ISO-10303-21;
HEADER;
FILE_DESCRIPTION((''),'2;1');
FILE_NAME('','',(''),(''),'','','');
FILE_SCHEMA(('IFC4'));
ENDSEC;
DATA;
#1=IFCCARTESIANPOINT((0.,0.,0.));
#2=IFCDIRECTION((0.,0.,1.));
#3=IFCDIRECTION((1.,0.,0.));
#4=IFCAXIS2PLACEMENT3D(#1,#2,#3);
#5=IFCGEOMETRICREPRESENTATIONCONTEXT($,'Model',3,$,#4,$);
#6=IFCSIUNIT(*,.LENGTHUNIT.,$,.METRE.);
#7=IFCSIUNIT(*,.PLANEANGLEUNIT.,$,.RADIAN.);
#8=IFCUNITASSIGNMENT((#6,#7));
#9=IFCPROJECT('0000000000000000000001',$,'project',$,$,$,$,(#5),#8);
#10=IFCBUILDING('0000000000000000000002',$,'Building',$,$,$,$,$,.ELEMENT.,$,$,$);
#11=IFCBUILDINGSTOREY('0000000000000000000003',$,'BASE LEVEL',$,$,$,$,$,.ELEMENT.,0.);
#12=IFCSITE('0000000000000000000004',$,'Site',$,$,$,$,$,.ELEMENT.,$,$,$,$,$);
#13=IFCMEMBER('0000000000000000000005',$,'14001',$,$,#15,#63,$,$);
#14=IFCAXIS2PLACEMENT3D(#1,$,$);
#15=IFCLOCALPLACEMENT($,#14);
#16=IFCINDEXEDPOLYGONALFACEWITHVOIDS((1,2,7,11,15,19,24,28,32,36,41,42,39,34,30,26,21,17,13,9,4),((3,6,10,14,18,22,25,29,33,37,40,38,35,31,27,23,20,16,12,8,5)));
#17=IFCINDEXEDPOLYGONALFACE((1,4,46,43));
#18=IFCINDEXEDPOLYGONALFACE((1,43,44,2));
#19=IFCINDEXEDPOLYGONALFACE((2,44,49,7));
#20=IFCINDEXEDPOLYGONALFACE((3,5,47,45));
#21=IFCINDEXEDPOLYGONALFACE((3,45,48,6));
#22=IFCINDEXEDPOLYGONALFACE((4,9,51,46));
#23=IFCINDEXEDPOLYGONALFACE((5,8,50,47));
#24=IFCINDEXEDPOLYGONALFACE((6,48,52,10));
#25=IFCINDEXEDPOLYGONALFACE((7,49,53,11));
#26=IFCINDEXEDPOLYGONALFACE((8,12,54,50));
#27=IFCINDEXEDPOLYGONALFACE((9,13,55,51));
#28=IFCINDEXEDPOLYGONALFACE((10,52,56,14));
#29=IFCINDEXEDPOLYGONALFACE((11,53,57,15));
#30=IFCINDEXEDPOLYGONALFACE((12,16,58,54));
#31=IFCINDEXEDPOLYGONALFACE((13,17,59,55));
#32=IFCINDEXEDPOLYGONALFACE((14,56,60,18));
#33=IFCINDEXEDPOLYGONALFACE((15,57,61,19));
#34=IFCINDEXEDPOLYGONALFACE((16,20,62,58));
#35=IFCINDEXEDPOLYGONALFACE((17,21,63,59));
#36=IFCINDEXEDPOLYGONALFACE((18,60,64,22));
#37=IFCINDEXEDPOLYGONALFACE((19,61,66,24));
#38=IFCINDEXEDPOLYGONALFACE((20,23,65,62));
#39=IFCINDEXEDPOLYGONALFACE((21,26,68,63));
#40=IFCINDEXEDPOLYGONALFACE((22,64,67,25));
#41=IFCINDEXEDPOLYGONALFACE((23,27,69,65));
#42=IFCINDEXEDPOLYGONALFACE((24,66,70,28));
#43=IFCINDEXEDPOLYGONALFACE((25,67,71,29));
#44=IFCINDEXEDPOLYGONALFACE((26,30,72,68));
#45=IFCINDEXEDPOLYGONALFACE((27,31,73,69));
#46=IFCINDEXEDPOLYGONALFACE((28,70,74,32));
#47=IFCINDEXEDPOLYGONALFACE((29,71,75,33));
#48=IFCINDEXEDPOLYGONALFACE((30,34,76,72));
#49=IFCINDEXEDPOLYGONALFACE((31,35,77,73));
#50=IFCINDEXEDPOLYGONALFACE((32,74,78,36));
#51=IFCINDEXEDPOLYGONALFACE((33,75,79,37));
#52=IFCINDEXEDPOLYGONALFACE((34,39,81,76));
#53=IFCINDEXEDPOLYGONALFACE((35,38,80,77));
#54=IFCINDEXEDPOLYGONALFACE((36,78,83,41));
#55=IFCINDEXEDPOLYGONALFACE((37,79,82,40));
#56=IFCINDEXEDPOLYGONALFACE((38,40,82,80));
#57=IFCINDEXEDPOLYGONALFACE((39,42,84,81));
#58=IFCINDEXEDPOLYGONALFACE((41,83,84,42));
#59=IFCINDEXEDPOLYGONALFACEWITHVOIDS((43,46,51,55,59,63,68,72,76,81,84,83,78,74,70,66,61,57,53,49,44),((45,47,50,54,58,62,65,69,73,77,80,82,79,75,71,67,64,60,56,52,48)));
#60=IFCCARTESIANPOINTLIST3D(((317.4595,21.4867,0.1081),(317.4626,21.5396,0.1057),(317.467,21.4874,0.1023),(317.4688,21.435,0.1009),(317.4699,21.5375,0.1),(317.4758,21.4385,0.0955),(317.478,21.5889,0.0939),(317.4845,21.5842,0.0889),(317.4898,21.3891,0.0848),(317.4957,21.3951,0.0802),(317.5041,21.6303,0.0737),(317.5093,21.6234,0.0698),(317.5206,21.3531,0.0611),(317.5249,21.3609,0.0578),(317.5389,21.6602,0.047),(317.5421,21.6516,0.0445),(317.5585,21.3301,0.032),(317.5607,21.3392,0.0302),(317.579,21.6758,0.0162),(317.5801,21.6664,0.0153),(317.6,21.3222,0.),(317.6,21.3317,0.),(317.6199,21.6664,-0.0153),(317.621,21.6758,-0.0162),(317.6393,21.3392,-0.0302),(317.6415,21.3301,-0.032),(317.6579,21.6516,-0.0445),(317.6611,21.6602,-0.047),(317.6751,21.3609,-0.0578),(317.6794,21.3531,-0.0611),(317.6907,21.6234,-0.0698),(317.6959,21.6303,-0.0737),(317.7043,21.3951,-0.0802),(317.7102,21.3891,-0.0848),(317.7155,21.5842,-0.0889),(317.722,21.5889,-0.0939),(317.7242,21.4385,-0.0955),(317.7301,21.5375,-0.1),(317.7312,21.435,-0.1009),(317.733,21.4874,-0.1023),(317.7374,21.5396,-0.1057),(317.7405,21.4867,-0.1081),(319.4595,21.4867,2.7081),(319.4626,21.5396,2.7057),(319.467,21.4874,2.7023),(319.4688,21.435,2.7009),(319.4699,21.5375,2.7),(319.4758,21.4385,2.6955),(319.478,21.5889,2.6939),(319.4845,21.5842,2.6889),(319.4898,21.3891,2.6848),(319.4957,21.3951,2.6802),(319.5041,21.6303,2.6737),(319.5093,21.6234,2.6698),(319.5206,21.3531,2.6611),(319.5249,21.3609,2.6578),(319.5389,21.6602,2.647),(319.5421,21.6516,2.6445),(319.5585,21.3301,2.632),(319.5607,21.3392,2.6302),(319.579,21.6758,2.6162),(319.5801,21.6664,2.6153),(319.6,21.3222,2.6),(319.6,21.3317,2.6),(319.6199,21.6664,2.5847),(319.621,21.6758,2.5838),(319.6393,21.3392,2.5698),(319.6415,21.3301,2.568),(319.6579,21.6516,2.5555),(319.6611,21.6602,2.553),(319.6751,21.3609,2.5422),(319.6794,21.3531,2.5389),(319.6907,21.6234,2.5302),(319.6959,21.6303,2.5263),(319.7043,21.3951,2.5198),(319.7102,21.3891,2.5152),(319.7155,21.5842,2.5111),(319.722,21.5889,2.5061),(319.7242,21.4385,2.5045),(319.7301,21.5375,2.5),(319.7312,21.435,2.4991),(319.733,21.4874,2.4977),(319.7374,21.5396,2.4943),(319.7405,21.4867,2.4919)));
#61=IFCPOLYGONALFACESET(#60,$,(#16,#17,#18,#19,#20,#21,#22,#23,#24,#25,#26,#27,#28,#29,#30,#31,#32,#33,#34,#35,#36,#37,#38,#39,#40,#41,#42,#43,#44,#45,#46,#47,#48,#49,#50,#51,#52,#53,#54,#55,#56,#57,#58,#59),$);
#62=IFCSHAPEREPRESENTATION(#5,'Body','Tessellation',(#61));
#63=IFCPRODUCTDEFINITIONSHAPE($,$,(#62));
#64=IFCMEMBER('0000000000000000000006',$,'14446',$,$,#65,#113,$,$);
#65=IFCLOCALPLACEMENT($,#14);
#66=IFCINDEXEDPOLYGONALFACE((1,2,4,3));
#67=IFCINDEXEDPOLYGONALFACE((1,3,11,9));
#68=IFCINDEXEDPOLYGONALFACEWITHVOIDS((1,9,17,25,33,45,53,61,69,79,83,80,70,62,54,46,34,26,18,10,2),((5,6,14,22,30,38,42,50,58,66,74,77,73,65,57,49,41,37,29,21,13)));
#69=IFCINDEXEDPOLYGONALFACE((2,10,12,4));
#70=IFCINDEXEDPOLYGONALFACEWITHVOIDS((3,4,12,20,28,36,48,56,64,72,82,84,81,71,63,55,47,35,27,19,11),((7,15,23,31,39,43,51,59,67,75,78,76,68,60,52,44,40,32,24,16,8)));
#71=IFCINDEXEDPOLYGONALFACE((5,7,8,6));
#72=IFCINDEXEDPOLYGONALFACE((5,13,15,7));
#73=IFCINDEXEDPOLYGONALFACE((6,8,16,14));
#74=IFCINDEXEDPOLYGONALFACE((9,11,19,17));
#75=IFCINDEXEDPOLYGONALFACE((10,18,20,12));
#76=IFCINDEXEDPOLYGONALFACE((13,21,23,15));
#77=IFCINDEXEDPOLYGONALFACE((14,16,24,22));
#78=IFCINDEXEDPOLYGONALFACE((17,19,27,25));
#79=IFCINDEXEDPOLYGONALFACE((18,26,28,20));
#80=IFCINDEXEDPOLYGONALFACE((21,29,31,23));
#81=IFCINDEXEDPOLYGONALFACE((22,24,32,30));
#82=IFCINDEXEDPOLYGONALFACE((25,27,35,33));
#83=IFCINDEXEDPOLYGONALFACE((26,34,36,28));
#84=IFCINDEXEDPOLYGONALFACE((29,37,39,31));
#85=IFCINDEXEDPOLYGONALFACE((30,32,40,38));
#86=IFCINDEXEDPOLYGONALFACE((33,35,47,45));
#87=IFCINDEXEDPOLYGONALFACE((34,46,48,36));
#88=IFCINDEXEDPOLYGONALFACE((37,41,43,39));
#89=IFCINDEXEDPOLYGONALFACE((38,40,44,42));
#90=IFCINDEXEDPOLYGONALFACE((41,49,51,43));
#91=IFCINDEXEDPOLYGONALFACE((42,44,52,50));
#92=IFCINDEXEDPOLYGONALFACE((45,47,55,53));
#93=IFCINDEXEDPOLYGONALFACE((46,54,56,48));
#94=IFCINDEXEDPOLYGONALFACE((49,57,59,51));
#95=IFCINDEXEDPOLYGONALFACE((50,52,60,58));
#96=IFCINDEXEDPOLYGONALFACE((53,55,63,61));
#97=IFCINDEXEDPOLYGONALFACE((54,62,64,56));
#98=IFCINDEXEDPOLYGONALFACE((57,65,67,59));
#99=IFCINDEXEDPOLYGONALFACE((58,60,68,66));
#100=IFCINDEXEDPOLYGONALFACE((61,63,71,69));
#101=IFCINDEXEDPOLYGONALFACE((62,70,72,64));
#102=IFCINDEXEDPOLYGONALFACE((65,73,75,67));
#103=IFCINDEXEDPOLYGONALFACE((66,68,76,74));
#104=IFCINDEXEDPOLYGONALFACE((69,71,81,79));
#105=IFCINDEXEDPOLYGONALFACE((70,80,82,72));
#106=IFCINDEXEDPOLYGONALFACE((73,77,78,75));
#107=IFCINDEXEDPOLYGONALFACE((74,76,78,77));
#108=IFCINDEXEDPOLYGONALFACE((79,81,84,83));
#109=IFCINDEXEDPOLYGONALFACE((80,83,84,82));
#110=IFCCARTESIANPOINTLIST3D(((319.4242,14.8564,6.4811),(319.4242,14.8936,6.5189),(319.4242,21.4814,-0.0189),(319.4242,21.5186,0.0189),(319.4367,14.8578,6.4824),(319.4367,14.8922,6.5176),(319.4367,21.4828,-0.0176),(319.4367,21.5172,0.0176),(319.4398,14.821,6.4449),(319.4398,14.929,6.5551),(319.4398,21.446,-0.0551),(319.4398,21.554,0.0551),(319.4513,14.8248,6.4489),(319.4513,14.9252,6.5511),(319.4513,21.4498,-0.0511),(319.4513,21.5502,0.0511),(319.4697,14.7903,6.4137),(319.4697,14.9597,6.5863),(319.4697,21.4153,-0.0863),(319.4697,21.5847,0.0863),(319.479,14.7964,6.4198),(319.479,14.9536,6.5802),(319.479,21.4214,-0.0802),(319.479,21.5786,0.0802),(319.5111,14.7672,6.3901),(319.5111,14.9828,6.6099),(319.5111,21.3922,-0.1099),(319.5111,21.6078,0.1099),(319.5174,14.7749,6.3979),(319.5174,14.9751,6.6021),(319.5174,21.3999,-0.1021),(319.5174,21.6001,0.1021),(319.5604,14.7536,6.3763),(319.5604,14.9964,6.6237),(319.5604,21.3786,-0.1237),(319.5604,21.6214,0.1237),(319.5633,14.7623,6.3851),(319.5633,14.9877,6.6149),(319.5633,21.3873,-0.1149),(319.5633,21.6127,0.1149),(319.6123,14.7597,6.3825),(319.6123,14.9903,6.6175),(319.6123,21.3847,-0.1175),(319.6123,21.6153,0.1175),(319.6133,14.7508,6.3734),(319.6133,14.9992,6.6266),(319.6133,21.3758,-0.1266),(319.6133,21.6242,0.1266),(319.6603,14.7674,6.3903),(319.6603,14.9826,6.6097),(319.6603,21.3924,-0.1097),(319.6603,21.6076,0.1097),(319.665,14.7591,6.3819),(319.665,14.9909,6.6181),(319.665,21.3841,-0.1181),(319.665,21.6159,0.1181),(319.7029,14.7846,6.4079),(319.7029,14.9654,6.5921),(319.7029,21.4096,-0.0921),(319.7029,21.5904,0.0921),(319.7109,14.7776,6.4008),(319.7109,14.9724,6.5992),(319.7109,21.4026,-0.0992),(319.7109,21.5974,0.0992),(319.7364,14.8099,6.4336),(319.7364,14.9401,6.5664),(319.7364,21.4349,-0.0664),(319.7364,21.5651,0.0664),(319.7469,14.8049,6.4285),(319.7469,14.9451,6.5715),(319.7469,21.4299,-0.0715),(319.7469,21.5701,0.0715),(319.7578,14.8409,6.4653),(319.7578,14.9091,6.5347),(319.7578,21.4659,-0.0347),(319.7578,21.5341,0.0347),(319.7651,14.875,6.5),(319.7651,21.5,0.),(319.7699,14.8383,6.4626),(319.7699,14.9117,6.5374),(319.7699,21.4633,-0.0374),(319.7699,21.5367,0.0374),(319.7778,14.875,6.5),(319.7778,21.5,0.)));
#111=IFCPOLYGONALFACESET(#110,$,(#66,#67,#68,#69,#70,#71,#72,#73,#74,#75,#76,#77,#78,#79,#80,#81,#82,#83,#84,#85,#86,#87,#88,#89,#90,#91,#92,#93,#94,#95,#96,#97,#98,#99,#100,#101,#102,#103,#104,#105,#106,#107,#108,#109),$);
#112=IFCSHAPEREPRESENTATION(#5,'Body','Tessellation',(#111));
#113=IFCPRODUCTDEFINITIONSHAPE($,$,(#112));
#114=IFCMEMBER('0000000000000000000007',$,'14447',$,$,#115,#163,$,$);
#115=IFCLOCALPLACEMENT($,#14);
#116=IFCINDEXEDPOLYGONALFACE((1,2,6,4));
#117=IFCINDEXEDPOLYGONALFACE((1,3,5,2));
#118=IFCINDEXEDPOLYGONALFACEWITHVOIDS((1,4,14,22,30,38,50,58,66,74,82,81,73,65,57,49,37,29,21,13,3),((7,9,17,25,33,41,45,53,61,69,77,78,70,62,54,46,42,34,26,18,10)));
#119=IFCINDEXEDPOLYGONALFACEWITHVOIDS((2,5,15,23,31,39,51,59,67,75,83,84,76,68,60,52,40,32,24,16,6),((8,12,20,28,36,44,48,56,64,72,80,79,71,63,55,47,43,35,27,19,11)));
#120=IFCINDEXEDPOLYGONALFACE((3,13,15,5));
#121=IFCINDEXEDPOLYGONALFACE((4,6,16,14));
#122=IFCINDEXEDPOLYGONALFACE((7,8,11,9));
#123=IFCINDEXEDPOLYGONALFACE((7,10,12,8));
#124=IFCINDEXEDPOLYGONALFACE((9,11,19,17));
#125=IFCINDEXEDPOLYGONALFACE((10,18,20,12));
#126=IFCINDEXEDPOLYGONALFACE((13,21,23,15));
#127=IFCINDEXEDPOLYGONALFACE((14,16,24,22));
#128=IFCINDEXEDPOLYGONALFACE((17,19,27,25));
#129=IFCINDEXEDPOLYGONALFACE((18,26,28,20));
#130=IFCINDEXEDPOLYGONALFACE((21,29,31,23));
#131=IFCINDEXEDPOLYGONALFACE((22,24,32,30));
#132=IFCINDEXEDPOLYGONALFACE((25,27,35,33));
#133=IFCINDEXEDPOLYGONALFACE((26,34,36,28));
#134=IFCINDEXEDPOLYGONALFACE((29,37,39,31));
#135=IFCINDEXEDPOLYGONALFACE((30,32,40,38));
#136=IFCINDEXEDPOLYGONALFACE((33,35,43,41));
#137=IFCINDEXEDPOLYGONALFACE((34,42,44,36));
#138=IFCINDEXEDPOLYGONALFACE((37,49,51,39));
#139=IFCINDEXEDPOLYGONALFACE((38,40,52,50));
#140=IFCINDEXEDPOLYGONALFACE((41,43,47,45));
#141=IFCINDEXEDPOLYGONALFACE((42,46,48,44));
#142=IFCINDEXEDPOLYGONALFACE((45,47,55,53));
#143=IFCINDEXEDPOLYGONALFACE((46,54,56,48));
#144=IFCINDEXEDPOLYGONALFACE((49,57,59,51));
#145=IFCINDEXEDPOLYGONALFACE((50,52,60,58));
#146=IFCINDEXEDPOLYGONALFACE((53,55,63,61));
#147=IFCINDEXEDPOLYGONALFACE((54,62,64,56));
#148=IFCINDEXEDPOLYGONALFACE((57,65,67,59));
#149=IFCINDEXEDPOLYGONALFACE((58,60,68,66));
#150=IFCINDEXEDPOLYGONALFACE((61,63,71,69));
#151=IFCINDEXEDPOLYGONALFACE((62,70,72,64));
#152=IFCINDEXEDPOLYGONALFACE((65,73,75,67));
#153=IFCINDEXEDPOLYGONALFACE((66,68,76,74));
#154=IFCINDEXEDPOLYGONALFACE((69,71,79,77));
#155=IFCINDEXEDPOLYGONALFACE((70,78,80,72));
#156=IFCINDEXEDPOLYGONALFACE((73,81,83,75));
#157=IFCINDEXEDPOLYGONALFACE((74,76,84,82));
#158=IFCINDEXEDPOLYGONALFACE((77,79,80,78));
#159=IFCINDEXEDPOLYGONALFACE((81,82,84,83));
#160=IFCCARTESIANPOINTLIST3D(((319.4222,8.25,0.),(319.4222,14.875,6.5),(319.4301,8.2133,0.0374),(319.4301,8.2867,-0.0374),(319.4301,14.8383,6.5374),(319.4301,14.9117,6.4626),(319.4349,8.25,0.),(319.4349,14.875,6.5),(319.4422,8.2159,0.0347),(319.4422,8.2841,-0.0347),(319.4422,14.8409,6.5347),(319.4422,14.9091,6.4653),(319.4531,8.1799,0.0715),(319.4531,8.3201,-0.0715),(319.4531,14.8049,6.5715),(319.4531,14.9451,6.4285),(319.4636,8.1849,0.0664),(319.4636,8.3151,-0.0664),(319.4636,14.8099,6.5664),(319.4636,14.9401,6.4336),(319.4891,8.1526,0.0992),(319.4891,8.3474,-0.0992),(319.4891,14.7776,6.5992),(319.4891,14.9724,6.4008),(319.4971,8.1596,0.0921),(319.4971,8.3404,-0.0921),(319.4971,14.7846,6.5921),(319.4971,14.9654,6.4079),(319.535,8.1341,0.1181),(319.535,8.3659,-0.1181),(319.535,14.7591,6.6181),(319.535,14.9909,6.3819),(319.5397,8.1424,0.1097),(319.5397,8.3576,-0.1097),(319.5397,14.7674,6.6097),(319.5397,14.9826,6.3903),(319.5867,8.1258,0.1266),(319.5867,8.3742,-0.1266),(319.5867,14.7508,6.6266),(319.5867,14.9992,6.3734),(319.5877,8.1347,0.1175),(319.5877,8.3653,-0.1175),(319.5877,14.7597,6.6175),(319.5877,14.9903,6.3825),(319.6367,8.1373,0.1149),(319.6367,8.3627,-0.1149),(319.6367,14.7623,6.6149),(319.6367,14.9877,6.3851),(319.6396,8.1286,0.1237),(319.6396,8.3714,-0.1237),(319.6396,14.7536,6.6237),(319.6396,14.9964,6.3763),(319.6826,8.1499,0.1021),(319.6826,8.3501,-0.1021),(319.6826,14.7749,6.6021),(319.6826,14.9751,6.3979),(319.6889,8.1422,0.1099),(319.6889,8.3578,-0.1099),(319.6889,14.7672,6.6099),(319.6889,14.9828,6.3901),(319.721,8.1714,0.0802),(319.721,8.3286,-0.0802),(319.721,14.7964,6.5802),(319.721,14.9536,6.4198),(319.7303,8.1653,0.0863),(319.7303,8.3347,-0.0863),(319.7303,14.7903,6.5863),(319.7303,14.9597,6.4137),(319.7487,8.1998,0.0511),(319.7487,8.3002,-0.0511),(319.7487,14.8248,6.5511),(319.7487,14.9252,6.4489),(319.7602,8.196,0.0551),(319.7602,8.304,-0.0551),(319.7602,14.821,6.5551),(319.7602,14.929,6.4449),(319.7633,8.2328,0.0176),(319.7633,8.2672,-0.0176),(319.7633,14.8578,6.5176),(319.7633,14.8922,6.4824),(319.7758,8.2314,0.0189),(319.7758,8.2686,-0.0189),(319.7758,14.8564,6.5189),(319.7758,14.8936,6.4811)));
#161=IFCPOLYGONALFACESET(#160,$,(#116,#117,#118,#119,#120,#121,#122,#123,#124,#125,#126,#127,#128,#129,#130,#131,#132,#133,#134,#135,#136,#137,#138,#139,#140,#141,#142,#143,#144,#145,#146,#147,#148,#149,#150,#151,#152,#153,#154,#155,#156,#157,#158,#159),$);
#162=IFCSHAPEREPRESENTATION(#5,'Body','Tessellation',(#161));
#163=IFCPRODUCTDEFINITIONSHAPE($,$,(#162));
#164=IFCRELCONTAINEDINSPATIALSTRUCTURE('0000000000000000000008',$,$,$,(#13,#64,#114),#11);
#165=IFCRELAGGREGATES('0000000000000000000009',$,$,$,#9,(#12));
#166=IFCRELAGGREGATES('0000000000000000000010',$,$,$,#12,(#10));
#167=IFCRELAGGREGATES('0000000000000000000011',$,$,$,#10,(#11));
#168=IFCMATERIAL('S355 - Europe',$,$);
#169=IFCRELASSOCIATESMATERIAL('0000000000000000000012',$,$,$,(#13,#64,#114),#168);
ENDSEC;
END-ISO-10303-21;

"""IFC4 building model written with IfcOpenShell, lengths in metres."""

from ifc_helpers import new_model, si_unit, frame, origin_with_axes, origin_2d_with_axis, place, context, project, spatial, hollow_circle, extrude, material, material_profile, profile_set, profile_usage, element, save


model = new_model("IFC4")

# Units and contexts
model_context = context("Model", 3, world=origin_with_axes())
ifc_project = project(units=[si_unit("LENGTHUNIT", "METRE"), si_unit("PLANEANGLEUNIT", "RADIAN")], contexts=[model_context])

# Site, building, storey
site = spatial("IfcSite", under=ifc_project, Name="Site", CompositionType="ELEMENT")
building = spatial("IfcBuilding", under=site, Name="Building", CompositionType="ELEMENT")
storey = spatial("IfcBuildingStorey", under=building, Name="BASE LEVEL", CompositionType="ELEMENT", Elevation=0.0)

# Shared definitions
ifc_material = material(Name="S355 - Europe")

# Members
ifc_material_profile_1 = material_profile(ifc_material, hollow_circle(Radius=0.1778, WallThickness=0.0095, at=origin_2d_with_axis()))
ifc_profile_set_1 = profile_set([ifc_material_profile_1])
ifc_profile_usage_1 = profile_usage(ifc_profile_set_1, cardinal=10)
member_1_placement = place(None, frame((319.6, 21.5, 2.6), z_axis=(-0.609711, 0.0, -0.792624), x_axis=(0.0, -1.0, 0.0)))
element("IfcMember", 1, at=member_1_placement, inside=storey, material=ifc_profile_usage_1, Name="14001", context=model_context, shape_type="SweptSolid", body=[
    extrude(hollow_circle(Radius=0.1778, WallThickness=0.0095, at=origin_2d_with_axis()), origin_with_axes(), (0.0, 0.0, 1.0), 3.2802),
])
ifc_material_profile_2 = material_profile(ifc_material, hollow_circle(Radius=0.1778, WallThickness=0.0127, at=origin_2d_with_axis()))
ifc_profile_set_2 = profile_set([ifc_material_profile_2])
ifc_profile_usage_2 = profile_usage(ifc_profile_set_2, cardinal=10)
member_2_placement = place(None, frame((319.6, 21.5, 0.0), z_axis=(0.0, -0.713809, 0.700341), x_axis=(1.0, 0.0, 0.0)))
element("IfcMember", 2, at=member_2_placement, inside=storey, material=ifc_profile_usage_2, Name="14446", context=model_context, shape_type="SweptSolid", body=[
    extrude(hollow_circle(Radius=0.1778, WallThickness=0.0127, at=origin_2d_with_axis()), origin_with_axes(), (0.0, 0.0, 1.0), 9.2812),
])
ifc_material_profile_3 = material_profile(ifc_material, hollow_circle(Radius=0.1778, WallThickness=0.0127, at=origin_2d_with_axis()))
ifc_profile_set_3 = profile_set([ifc_material_profile_3])
ifc_profile_usage_3 = profile_usage(ifc_profile_set_3, cardinal=10)
member_3_placement = place(None, frame((319.6, 8.25, 0.0), z_axis=(0.0, 0.713809, 0.700341), x_axis=(-1.0, 0.0, 0.0)))
element("IfcMember", 3, at=member_3_placement, inside=storey, material=ifc_profile_usage_3, Name="14447", context=model_context, shape_type="SweptSolid", body=[
    extrude(hollow_circle(Radius=0.1778, WallThickness=0.0127, at=origin_2d_with_axis()), origin_with_axes(), (0.0, 0.0, 1.0), 9.2812),
])

save(model, "model.ifc")
